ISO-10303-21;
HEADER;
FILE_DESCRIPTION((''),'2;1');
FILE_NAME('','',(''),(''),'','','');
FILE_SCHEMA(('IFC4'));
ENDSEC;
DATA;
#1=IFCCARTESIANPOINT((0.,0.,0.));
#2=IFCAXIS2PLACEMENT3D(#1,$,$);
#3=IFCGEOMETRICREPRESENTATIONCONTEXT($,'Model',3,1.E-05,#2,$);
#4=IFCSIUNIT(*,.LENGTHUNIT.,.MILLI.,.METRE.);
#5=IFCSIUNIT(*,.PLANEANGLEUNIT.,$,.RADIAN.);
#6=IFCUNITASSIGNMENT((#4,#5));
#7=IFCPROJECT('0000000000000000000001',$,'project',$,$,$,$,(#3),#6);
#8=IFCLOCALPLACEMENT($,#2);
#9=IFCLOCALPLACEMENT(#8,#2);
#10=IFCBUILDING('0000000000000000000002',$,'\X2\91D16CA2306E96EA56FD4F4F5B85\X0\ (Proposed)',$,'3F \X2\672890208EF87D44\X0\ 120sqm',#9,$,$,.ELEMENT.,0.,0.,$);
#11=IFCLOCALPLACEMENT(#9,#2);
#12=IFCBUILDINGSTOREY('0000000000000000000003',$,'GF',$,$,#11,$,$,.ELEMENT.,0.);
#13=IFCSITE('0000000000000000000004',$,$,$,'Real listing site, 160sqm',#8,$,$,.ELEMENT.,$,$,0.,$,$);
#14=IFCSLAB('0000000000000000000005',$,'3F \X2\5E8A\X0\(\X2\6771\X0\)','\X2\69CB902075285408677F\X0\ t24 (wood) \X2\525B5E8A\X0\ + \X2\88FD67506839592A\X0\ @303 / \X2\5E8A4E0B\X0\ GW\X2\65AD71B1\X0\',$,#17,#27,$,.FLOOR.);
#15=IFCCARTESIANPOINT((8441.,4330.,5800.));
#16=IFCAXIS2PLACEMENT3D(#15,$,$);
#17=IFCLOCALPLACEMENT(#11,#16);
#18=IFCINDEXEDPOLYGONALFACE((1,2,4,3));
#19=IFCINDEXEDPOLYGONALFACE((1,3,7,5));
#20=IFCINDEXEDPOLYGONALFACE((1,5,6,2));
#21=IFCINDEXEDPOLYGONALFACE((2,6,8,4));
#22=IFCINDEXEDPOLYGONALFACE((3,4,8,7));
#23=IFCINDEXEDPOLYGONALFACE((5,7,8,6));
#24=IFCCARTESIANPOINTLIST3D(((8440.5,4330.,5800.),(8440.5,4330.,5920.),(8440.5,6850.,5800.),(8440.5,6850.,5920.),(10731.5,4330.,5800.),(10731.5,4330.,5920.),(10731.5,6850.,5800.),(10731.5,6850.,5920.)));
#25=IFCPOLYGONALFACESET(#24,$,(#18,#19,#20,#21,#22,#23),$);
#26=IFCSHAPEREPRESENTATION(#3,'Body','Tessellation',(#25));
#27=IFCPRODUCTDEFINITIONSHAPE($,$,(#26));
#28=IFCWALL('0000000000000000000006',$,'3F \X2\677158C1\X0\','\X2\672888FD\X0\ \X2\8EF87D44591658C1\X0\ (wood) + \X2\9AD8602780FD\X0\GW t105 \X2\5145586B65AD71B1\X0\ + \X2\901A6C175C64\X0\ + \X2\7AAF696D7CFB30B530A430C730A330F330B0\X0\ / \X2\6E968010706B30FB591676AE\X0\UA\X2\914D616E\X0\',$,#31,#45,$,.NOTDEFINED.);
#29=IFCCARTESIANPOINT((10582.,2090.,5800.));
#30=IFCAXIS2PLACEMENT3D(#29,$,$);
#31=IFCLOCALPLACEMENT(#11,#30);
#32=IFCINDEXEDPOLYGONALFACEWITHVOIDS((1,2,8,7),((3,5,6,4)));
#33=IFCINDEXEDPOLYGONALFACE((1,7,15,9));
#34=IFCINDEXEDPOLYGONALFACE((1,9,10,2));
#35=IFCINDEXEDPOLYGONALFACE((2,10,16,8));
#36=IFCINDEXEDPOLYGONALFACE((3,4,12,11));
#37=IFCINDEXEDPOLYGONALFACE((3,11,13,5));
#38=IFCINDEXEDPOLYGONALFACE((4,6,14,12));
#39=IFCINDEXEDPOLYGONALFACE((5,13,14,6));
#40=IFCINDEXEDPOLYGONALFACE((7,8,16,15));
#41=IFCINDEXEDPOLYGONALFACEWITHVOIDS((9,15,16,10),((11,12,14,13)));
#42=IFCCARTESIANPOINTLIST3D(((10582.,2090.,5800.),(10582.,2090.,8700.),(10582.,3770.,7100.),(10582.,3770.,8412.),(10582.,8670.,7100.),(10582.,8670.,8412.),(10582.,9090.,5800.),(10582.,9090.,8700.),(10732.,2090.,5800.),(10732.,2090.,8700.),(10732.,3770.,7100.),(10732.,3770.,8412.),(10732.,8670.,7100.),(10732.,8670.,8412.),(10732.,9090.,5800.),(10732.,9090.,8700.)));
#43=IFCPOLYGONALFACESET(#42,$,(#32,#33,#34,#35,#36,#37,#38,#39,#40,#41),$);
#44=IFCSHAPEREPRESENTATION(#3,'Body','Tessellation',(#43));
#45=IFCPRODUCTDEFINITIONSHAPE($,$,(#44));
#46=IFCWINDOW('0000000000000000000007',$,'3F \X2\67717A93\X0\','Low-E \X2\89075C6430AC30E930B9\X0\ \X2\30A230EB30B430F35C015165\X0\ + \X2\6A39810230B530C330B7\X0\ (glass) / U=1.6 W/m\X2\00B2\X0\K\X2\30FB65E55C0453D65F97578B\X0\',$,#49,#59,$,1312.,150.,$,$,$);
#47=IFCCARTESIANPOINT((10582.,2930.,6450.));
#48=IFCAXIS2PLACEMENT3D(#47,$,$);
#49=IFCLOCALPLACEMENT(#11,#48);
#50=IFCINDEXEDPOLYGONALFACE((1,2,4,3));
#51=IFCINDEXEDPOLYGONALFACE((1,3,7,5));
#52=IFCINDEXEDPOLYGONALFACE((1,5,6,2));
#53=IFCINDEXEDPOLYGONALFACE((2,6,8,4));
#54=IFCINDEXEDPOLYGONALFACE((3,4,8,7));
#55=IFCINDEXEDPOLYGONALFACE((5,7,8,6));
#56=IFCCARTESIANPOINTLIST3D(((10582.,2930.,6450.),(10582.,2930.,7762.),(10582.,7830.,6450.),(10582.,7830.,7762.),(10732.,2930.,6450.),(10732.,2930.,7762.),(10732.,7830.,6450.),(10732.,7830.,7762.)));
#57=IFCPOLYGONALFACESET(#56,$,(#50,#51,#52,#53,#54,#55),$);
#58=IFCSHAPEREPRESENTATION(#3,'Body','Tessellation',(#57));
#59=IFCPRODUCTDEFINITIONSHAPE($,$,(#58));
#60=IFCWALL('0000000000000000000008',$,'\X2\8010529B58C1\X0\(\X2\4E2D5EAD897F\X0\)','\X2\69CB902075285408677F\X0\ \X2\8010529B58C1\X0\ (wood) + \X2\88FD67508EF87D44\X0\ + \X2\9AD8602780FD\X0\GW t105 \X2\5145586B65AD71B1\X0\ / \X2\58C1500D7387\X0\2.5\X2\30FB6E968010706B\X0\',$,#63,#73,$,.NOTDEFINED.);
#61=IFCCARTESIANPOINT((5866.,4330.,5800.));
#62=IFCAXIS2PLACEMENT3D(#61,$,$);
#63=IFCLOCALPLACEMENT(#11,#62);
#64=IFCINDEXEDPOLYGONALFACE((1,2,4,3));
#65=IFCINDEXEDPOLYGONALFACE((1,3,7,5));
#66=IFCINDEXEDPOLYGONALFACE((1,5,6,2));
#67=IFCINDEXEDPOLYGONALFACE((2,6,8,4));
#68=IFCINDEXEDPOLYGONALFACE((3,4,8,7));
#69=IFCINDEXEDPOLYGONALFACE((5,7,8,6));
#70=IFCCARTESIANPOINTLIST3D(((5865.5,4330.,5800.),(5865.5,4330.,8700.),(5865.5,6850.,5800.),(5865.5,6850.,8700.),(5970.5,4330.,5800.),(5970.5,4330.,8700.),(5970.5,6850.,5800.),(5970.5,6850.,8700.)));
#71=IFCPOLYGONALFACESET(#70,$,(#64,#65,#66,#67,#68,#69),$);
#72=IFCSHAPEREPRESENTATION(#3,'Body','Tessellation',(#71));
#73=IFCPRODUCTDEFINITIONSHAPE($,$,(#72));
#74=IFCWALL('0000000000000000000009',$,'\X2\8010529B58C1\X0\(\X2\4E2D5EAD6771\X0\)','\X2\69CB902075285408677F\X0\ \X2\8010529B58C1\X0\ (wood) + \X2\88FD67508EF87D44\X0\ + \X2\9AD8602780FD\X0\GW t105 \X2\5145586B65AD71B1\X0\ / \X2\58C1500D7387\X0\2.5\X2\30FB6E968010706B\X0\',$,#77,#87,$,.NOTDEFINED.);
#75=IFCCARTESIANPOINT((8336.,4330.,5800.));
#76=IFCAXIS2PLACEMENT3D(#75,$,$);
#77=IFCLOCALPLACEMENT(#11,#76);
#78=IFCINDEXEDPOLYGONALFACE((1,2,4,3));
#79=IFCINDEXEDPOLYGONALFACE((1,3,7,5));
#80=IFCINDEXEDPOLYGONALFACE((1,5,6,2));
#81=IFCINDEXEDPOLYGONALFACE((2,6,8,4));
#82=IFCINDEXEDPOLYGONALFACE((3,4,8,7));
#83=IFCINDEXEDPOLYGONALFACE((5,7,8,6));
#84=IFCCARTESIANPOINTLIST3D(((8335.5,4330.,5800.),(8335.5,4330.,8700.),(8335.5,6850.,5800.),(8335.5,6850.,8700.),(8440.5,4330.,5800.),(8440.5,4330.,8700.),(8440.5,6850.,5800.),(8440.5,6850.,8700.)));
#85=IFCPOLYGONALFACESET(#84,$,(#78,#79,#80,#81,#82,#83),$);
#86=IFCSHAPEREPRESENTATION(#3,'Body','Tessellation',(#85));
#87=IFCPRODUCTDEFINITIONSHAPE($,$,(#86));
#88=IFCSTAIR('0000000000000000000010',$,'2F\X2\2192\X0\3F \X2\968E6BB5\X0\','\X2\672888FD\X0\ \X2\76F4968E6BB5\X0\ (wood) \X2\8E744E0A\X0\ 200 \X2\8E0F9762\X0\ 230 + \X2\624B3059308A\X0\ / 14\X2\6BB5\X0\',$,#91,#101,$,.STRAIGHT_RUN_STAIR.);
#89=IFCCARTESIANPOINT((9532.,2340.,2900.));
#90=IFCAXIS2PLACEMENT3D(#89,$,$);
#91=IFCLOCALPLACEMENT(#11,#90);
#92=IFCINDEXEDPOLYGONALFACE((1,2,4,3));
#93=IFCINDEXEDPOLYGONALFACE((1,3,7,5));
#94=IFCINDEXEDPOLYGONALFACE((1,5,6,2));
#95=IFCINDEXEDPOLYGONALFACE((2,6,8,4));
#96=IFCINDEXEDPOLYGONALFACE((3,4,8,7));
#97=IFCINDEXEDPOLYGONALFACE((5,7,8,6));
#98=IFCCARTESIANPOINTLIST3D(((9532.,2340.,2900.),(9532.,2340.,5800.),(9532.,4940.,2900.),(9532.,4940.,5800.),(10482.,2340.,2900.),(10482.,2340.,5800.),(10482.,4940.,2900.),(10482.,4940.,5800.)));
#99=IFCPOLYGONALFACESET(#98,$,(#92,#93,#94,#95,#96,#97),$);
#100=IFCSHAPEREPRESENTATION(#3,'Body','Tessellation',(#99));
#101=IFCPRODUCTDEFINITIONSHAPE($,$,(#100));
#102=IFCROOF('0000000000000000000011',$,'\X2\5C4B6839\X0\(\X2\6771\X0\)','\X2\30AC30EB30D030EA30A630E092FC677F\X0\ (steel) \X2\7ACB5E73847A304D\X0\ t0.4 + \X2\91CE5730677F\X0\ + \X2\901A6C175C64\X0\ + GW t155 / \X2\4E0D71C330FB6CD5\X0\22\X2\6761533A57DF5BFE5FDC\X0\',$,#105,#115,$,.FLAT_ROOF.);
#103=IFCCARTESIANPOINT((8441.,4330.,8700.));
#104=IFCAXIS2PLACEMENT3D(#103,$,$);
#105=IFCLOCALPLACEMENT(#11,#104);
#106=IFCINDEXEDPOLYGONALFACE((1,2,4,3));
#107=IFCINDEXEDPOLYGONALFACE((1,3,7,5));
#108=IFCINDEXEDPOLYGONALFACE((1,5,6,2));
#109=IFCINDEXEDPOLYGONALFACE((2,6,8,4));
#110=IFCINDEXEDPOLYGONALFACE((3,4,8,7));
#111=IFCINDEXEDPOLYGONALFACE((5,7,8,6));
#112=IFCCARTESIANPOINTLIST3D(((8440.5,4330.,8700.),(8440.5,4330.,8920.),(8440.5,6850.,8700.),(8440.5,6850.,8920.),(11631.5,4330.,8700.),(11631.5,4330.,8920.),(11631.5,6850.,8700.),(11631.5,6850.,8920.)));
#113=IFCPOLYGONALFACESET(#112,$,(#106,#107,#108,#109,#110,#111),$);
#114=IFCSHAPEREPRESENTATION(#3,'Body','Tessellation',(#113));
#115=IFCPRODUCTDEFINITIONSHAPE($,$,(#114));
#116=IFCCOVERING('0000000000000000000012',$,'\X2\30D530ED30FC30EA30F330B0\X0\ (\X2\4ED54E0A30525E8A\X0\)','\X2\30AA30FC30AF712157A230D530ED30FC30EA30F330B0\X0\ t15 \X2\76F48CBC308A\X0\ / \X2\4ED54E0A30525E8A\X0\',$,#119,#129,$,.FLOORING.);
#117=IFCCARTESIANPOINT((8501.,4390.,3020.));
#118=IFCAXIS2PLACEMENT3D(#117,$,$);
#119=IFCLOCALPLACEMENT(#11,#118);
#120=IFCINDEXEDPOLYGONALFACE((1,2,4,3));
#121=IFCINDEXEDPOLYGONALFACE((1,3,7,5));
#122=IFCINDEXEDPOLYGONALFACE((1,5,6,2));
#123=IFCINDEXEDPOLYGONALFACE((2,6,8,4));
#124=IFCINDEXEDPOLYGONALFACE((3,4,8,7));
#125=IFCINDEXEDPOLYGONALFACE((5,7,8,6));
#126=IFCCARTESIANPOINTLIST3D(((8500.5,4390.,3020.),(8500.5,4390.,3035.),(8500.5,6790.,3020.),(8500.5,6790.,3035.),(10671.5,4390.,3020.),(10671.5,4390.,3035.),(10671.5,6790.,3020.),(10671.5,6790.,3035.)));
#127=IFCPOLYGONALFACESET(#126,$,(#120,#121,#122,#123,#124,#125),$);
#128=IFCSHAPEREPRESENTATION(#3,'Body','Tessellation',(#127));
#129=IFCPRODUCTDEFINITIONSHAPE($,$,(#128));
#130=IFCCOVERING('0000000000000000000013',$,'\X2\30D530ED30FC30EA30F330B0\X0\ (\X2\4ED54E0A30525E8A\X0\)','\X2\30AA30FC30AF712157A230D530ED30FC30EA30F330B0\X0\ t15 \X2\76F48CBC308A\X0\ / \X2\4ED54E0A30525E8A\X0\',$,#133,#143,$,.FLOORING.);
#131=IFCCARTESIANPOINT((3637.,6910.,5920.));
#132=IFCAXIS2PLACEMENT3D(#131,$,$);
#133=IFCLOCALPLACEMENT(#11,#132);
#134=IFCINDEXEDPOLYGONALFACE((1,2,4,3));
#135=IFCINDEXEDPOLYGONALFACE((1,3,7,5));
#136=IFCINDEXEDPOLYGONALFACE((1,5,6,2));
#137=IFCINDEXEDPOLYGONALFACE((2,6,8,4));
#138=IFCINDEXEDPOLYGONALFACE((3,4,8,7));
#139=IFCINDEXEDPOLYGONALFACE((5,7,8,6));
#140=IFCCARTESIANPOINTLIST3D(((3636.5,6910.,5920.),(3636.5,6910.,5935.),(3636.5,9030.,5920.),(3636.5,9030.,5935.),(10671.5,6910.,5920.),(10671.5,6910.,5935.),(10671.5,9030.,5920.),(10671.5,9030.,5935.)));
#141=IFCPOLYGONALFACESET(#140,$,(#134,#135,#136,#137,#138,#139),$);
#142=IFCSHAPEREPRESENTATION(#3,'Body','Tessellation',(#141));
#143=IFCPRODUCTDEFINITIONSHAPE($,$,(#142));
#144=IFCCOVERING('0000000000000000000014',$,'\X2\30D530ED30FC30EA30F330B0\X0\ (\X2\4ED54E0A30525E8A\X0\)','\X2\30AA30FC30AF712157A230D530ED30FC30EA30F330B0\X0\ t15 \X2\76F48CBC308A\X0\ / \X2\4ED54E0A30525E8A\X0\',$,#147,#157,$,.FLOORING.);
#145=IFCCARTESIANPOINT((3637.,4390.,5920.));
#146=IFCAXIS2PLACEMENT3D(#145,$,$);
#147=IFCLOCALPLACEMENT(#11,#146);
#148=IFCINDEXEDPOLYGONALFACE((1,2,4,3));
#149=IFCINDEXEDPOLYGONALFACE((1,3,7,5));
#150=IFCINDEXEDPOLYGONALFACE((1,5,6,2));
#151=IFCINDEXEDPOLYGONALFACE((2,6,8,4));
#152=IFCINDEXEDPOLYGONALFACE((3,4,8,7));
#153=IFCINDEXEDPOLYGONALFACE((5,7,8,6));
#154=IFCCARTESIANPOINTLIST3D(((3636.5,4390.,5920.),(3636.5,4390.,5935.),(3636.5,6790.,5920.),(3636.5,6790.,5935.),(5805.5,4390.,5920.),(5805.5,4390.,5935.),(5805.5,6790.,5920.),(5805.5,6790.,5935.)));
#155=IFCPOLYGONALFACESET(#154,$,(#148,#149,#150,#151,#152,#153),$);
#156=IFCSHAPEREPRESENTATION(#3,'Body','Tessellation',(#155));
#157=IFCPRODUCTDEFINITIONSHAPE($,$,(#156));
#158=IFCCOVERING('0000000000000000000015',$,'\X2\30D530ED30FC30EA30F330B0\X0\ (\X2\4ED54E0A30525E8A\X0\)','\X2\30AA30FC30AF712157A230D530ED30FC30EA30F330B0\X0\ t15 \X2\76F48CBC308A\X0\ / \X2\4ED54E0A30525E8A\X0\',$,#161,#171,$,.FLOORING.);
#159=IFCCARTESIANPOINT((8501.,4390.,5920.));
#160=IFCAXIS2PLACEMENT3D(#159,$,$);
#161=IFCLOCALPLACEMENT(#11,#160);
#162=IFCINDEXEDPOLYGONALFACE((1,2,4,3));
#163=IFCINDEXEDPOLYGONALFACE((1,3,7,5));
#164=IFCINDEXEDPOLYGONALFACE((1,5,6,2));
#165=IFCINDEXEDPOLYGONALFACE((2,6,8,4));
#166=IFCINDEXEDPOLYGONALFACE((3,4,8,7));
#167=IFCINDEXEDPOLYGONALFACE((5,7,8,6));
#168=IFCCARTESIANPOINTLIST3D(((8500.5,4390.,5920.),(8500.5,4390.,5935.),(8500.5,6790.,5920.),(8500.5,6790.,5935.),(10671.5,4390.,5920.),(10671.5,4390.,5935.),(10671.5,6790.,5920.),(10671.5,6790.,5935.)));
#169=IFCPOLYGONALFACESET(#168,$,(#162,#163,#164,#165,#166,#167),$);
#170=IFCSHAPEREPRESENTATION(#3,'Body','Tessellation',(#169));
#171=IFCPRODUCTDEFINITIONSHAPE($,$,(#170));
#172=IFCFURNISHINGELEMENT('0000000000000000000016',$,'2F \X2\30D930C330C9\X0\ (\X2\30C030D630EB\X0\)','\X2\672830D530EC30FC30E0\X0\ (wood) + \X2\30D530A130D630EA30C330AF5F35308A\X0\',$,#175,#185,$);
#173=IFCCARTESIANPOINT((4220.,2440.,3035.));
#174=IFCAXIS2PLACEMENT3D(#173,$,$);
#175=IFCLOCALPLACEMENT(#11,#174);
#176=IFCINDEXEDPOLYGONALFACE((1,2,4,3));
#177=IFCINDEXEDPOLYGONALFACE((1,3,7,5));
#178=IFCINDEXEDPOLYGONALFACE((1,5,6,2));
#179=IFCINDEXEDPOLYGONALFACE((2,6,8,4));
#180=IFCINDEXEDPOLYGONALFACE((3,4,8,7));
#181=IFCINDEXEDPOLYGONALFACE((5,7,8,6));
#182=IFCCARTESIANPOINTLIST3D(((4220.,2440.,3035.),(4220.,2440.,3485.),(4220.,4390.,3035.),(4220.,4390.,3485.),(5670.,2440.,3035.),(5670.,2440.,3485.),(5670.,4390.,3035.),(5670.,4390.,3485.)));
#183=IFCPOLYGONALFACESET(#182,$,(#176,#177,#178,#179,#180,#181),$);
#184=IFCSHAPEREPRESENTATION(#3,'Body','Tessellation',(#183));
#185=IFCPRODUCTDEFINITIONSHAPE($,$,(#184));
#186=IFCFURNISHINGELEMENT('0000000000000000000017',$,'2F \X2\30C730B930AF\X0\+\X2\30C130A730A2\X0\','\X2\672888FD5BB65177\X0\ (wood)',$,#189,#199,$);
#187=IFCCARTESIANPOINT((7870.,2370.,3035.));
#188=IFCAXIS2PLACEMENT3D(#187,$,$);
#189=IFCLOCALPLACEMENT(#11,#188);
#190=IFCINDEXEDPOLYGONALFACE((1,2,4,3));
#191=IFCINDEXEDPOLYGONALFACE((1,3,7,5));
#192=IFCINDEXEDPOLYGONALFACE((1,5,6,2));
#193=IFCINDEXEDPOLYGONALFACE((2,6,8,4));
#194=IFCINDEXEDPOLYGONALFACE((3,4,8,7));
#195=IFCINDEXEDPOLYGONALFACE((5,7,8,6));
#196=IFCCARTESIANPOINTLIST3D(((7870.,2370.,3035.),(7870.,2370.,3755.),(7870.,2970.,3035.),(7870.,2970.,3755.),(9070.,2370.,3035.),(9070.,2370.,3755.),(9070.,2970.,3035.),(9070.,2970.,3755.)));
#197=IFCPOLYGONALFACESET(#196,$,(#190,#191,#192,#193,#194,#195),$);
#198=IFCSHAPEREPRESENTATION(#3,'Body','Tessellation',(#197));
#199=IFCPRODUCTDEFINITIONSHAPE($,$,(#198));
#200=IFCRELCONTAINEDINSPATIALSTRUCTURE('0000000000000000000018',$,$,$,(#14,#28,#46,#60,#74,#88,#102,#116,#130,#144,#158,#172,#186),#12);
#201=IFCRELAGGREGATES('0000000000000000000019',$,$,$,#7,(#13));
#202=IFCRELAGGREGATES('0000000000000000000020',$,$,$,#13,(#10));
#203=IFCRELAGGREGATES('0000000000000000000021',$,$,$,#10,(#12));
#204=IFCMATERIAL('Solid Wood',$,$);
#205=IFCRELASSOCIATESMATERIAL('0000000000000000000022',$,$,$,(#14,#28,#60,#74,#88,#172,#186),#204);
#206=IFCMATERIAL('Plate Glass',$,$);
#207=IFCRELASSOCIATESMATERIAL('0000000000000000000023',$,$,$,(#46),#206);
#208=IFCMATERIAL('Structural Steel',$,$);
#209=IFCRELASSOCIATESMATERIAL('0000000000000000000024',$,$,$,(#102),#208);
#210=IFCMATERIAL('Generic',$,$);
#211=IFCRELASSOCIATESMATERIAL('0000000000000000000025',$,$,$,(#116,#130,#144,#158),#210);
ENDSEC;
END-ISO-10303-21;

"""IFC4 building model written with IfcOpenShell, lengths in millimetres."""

from ifc_helpers import new_model, si_unit, frame, frame_2d, origin, place, context, project, spatial, rectangle, extrude, material, element, fill, save


model = new_model("IFC4")

# Units and contexts
model_context = context("Model", 3, precision=1e-05, world=origin())
ifc_project = project(units=[si_unit("LENGTHUNIT", "METRE", prefix="MILLI"), si_unit("PLANEANGLEUNIT", "RADIAN")], contexts=[model_context])

# Site, building, storey
site_placement = place(None, origin())
site = spatial("IfcSite", under=ifc_project, at=site_placement, ObjectType="Real listing site, 160sqm", CompositionType="ELEMENT", RefElevation=0.0)
building_placement = place(site_placement, origin())
building = spatial("IfcBuilding", under=site, at=building_placement, Name="金沢の雪国住宅 (Proposed)", ObjectType="3F 木造軸組 120sqm", CompositionType="ELEMENT", ElevationOfRefHeight=0.0, ElevationOfTerrain=0.0)
storey_placement = place(building_placement, origin())
storey = spatial("IfcBuildingStorey", under=building, at=storey_placement, Name="GF", CompositionType="ELEMENT", Elevation=0.0)

# Slab
ifc_material_1 = material(Name="Solid Wood")
slab_placement = place(storey_placement, frame((8441.0, 4330.0, 5800.0)))
element("IfcSlab", 1, at=slab_placement, inside=storey, material=ifc_material_1, Name="3F 床(東)", Description="構造用合板 t24 (wood) 剛床 + 製材根太 @303 / 床下 GW断熱", PredefinedType="FLOOR", context=model_context, shape_type="SweptSolid", body=[
    extrude(rectangle(XDim=2291.0, YDim=2520.0, at=frame_2d((1145.0, 1260.0))), frame((8441.0, 4330.0, 5800.0)), (0.0, 0.0, 1.0), 120.0),
])

# Wall, opening, window
wall_1_placement = place(storey_placement, frame((10582.0, 2090.0, 5800.0)))
wall_1 = element("IfcWall", 2, at=wall_1_placement, inside=storey, material=ifc_material_1, Name="3F 東壁", Description="木製 軸組外壁 (wood) + 高性能GW t105 充填断熱 + 通気層 + 窯業系サイディング / 準耐火・外皮UA配慮", PredefinedType="NOTDEFINED", context=model_context, shape_type="SweptSolid", body=[
    extrude(rectangle(XDim=150.0, YDim=7000.0, at=frame_2d((75.0, 3500.0))), frame((10582.0, 2090.0, 5800.0)), (0.0, 0.0, 1.0), 2900.0),
])
opening_1_placement = place(storey_placement, frame((10582.0, 2930.0, 6450.0)))
opening_1 = element("IfcOpeningElement", 3, at=opening_1_placement, cuts=wall_1, PredefinedType="NOTDEFINED", context=model_context, shape_type="SweptSolid", body=[
    extrude(rectangle(XDim=150.0, YDim=4900.0, at=frame_2d((75.0, 2450.0))), frame((10582.0, 2930.0, 6450.0)), (0.0, 0.0, 1.0), 1312.0),
])
ifc_material_2 = material(Name="Plate Glass")
window_1_placement = place(storey_placement, frame((10582.0, 2930.0, 6450.0)))
window_1 = element("IfcWindow", 4, at=window_1_placement, inside=storey, material=ifc_material_2, Name="3F 東窓", Description="Low-E 複層ガラス アルゴン封入 + 樹脂サッシ (glass) / U=1.6 W/m²K・日射取得型", OverallHeight=1312.0, OverallWidth=150.0, context=model_context, shape_type="SweptSolid", body=[
    extrude(rectangle(XDim=150.0, YDim=4900.0, at=frame_2d((75.0, 2450.0))), frame((10582.0, 2930.0, 6450.0)), (0.0, 0.0, 1.0), 1312.0),
])
fill(opening_1, window_1)

# Walls
wall_2_placement = place(storey_placement, frame((5866.0, 4330.0, 5800.0)))
element("IfcWall", 5, at=wall_2_placement, inside=storey, material=ifc_material_1, Name="耐力壁(中庭西)", Description="構造用合板 耐力壁 (wood) + 製材軸組 + 高性能GW t105 充填断熱 / 壁倍率2.5・準耐火", PredefinedType="NOTDEFINED", context=model_context, shape_type="SweptSolid", body=[
    extrude(rectangle(XDim=105.0, YDim=2520.0, at=frame_2d((52.0, 1260.0))), frame((5866.0, 4330.0, 5800.0)), (0.0, 0.0, 1.0), 2900.0),
])
wall_3_placement = place(storey_placement, frame((8336.0, 4330.0, 5800.0)))
element("IfcWall", 6, at=wall_3_placement, inside=storey, material=ifc_material_1, Name="耐力壁(中庭東)", Description="構造用合板 耐力壁 (wood) + 製材軸組 + 高性能GW t105 充填断熱 / 壁倍率2.5・準耐火", PredefinedType="NOTDEFINED", context=model_context, shape_type="SweptSolid", body=[
    extrude(rectangle(XDim=105.0, YDim=2520.0, at=frame_2d((52.0, 1260.0))), frame((8336.0, 4330.0, 5800.0)), (0.0, 0.0, 1.0), 2900.0),
])

# Stair
stair_placement = place(storey_placement, frame((9532.0, 2340.0, 2900.0)))
element("IfcStair", 7, at=stair_placement, inside=storey, material=ifc_material_1, Name="2F→3F 階段", Description="木製 直階段 (wood) 蹴上 200 踏面 230 + 手すり / 14段", PredefinedType="STRAIGHT_RUN_STAIR", context=model_context, shape_type="SweptSolid", body=[
    extrude(rectangle(XDim=950.0, YDim=2600.0, at=frame_2d((475.0, 1300.0))), frame((9532.0, 2340.0, 2900.0)), (0.0, 0.0, 1.0), 2900.0),
])

# Roof
ifc_material_3 = material(Name="Structural Steel")
for number, where, name in (
    (8, (8441.0, 4330.0, 8700.0), "屋根(東)"),
):
    element("IfcRoof", number, at=place(storey_placement, frame(where)), inside=storey, material=ifc_material_3, Name=name, Description="ガルバリウム鋼板 (steel) 立平葺き t0.4 + 野地板 + 通気層 + GW t155 / 不燃・法22条区域対応", PredefinedType="FLAT_ROOF", context=model_context, shape_type="SweptSolid", body=[
        extrude(rectangle(XDim=3191.0, YDim=2520.0, at=frame_2d((1595.0, 1260.0))), frame((8441.0, 4330.0, 8700.0)), (0.0, 0.0, 1.0), 220.0),
    ])

# Coverings
ifc_material_4 = material(Name="Generic")
covering_1_placement = place(storey_placement, frame((8501.0, 4390.0, 3020.0)))
element("IfcCovering", 9, at=covering_1_placement, inside=storey, material=ifc_material_4, Name="フローリング (仕上げ床)", Description="オーク無垢フローリング t15 直貼り / 仕上げ床", PredefinedType="FLOORING", context=model_context, shape_type="SweptSolid", body=[
    extrude(rectangle(XDim=2171.0, YDim=2400.0, at=frame_2d((1085.0, 1200.0))), frame((8501.0, 4390.0, 3020.0)), (0.0, 0.0, 1.0), 15.0),
])
covering_2_placement = place(storey_placement, frame((3637.0, 6910.0, 5920.0)))
element("IfcCovering", 10, at=covering_2_placement, inside=storey, material=ifc_material_4, Name="フローリング (仕上げ床)", Description="オーク無垢フローリング t15 直貼り / 仕上げ床", PredefinedType="FLOORING", context=model_context, shape_type="SweptSolid", body=[
    extrude(rectangle(XDim=7035.0, YDim=2120.0, at=frame_2d((3517.0, 1060.0))), frame((3637.0, 6910.0, 5920.0)), (0.0, 0.0, 1.0), 15.0),
])
covering_3_placement = place(storey_placement, frame((3637.0, 4390.0, 5920.0)))
element("IfcCovering", 11, at=covering_3_placement, inside=storey, material=ifc_material_4, Name="フローリング (仕上げ床)", Description="オーク無垢フローリング t15 直貼り / 仕上げ床", PredefinedType="FLOORING", context=model_context, shape_type="SweptSolid", body=[
    extrude(rectangle(XDim=2169.0, YDim=2400.0, at=frame_2d((1084.0, 1200.0))), frame((3637.0, 4390.0, 5920.0)), (0.0, 0.0, 1.0), 15.0),
])
covering_4_placement = place(storey_placement, frame((8501.0, 4390.0, 5920.0)))
element("IfcCovering", 12, at=covering_4_placement, inside=storey, material=ifc_material_4, Name="フローリング (仕上げ床)", Description="オーク無垢フローリング t15 直貼り / 仕上げ床", PredefinedType="FLOORING", context=model_context, shape_type="SweptSolid", body=[
    extrude(rectangle(XDim=2171.0, YDim=2400.0, at=frame_2d((1085.0, 1200.0))), frame((8501.0, 4390.0, 5920.0)), (0.0, 0.0, 1.0), 15.0),
])

# Furnishing elements
furnishing_1_placement = place(storey_placement, frame((4220.0, 2440.0, 3035.0)))
element("IfcFurnishingElement", 13, at=furnishing_1_placement, inside=storey, material=ifc_material_1, Name="2F ベッド (ダブル)", Description="木フレーム (wood) + ファブリック張り", context=model_context, shape_type="SweptSolid", body=[
    extrude(rectangle(XDim=1450.0, YDim=1950.0, at=frame_2d((725.0, 975.0))), frame((4220.0, 2440.0, 3035.0)), (0.0, 0.0, 1.0), 450.0),
])
furnishing_2_placement = place(storey_placement, frame((7870.0, 2370.0, 3035.0)))
element("IfcFurnishingElement", 14, at=furnishing_2_placement, inside=storey, material=ifc_material_1, Name="2F デスク+チェア", Description="木製家具 (wood)", context=model_context, shape_type="SweptSolid", body=[
    extrude(rectangle(XDim=1200.0, YDim=600.0, at=frame_2d((600.0, 300.0))), frame((7870.0, 2370.0, 3035.0)), (0.0, 0.0, 1.0), 720.0),
])

save(model, "model.ifc")
